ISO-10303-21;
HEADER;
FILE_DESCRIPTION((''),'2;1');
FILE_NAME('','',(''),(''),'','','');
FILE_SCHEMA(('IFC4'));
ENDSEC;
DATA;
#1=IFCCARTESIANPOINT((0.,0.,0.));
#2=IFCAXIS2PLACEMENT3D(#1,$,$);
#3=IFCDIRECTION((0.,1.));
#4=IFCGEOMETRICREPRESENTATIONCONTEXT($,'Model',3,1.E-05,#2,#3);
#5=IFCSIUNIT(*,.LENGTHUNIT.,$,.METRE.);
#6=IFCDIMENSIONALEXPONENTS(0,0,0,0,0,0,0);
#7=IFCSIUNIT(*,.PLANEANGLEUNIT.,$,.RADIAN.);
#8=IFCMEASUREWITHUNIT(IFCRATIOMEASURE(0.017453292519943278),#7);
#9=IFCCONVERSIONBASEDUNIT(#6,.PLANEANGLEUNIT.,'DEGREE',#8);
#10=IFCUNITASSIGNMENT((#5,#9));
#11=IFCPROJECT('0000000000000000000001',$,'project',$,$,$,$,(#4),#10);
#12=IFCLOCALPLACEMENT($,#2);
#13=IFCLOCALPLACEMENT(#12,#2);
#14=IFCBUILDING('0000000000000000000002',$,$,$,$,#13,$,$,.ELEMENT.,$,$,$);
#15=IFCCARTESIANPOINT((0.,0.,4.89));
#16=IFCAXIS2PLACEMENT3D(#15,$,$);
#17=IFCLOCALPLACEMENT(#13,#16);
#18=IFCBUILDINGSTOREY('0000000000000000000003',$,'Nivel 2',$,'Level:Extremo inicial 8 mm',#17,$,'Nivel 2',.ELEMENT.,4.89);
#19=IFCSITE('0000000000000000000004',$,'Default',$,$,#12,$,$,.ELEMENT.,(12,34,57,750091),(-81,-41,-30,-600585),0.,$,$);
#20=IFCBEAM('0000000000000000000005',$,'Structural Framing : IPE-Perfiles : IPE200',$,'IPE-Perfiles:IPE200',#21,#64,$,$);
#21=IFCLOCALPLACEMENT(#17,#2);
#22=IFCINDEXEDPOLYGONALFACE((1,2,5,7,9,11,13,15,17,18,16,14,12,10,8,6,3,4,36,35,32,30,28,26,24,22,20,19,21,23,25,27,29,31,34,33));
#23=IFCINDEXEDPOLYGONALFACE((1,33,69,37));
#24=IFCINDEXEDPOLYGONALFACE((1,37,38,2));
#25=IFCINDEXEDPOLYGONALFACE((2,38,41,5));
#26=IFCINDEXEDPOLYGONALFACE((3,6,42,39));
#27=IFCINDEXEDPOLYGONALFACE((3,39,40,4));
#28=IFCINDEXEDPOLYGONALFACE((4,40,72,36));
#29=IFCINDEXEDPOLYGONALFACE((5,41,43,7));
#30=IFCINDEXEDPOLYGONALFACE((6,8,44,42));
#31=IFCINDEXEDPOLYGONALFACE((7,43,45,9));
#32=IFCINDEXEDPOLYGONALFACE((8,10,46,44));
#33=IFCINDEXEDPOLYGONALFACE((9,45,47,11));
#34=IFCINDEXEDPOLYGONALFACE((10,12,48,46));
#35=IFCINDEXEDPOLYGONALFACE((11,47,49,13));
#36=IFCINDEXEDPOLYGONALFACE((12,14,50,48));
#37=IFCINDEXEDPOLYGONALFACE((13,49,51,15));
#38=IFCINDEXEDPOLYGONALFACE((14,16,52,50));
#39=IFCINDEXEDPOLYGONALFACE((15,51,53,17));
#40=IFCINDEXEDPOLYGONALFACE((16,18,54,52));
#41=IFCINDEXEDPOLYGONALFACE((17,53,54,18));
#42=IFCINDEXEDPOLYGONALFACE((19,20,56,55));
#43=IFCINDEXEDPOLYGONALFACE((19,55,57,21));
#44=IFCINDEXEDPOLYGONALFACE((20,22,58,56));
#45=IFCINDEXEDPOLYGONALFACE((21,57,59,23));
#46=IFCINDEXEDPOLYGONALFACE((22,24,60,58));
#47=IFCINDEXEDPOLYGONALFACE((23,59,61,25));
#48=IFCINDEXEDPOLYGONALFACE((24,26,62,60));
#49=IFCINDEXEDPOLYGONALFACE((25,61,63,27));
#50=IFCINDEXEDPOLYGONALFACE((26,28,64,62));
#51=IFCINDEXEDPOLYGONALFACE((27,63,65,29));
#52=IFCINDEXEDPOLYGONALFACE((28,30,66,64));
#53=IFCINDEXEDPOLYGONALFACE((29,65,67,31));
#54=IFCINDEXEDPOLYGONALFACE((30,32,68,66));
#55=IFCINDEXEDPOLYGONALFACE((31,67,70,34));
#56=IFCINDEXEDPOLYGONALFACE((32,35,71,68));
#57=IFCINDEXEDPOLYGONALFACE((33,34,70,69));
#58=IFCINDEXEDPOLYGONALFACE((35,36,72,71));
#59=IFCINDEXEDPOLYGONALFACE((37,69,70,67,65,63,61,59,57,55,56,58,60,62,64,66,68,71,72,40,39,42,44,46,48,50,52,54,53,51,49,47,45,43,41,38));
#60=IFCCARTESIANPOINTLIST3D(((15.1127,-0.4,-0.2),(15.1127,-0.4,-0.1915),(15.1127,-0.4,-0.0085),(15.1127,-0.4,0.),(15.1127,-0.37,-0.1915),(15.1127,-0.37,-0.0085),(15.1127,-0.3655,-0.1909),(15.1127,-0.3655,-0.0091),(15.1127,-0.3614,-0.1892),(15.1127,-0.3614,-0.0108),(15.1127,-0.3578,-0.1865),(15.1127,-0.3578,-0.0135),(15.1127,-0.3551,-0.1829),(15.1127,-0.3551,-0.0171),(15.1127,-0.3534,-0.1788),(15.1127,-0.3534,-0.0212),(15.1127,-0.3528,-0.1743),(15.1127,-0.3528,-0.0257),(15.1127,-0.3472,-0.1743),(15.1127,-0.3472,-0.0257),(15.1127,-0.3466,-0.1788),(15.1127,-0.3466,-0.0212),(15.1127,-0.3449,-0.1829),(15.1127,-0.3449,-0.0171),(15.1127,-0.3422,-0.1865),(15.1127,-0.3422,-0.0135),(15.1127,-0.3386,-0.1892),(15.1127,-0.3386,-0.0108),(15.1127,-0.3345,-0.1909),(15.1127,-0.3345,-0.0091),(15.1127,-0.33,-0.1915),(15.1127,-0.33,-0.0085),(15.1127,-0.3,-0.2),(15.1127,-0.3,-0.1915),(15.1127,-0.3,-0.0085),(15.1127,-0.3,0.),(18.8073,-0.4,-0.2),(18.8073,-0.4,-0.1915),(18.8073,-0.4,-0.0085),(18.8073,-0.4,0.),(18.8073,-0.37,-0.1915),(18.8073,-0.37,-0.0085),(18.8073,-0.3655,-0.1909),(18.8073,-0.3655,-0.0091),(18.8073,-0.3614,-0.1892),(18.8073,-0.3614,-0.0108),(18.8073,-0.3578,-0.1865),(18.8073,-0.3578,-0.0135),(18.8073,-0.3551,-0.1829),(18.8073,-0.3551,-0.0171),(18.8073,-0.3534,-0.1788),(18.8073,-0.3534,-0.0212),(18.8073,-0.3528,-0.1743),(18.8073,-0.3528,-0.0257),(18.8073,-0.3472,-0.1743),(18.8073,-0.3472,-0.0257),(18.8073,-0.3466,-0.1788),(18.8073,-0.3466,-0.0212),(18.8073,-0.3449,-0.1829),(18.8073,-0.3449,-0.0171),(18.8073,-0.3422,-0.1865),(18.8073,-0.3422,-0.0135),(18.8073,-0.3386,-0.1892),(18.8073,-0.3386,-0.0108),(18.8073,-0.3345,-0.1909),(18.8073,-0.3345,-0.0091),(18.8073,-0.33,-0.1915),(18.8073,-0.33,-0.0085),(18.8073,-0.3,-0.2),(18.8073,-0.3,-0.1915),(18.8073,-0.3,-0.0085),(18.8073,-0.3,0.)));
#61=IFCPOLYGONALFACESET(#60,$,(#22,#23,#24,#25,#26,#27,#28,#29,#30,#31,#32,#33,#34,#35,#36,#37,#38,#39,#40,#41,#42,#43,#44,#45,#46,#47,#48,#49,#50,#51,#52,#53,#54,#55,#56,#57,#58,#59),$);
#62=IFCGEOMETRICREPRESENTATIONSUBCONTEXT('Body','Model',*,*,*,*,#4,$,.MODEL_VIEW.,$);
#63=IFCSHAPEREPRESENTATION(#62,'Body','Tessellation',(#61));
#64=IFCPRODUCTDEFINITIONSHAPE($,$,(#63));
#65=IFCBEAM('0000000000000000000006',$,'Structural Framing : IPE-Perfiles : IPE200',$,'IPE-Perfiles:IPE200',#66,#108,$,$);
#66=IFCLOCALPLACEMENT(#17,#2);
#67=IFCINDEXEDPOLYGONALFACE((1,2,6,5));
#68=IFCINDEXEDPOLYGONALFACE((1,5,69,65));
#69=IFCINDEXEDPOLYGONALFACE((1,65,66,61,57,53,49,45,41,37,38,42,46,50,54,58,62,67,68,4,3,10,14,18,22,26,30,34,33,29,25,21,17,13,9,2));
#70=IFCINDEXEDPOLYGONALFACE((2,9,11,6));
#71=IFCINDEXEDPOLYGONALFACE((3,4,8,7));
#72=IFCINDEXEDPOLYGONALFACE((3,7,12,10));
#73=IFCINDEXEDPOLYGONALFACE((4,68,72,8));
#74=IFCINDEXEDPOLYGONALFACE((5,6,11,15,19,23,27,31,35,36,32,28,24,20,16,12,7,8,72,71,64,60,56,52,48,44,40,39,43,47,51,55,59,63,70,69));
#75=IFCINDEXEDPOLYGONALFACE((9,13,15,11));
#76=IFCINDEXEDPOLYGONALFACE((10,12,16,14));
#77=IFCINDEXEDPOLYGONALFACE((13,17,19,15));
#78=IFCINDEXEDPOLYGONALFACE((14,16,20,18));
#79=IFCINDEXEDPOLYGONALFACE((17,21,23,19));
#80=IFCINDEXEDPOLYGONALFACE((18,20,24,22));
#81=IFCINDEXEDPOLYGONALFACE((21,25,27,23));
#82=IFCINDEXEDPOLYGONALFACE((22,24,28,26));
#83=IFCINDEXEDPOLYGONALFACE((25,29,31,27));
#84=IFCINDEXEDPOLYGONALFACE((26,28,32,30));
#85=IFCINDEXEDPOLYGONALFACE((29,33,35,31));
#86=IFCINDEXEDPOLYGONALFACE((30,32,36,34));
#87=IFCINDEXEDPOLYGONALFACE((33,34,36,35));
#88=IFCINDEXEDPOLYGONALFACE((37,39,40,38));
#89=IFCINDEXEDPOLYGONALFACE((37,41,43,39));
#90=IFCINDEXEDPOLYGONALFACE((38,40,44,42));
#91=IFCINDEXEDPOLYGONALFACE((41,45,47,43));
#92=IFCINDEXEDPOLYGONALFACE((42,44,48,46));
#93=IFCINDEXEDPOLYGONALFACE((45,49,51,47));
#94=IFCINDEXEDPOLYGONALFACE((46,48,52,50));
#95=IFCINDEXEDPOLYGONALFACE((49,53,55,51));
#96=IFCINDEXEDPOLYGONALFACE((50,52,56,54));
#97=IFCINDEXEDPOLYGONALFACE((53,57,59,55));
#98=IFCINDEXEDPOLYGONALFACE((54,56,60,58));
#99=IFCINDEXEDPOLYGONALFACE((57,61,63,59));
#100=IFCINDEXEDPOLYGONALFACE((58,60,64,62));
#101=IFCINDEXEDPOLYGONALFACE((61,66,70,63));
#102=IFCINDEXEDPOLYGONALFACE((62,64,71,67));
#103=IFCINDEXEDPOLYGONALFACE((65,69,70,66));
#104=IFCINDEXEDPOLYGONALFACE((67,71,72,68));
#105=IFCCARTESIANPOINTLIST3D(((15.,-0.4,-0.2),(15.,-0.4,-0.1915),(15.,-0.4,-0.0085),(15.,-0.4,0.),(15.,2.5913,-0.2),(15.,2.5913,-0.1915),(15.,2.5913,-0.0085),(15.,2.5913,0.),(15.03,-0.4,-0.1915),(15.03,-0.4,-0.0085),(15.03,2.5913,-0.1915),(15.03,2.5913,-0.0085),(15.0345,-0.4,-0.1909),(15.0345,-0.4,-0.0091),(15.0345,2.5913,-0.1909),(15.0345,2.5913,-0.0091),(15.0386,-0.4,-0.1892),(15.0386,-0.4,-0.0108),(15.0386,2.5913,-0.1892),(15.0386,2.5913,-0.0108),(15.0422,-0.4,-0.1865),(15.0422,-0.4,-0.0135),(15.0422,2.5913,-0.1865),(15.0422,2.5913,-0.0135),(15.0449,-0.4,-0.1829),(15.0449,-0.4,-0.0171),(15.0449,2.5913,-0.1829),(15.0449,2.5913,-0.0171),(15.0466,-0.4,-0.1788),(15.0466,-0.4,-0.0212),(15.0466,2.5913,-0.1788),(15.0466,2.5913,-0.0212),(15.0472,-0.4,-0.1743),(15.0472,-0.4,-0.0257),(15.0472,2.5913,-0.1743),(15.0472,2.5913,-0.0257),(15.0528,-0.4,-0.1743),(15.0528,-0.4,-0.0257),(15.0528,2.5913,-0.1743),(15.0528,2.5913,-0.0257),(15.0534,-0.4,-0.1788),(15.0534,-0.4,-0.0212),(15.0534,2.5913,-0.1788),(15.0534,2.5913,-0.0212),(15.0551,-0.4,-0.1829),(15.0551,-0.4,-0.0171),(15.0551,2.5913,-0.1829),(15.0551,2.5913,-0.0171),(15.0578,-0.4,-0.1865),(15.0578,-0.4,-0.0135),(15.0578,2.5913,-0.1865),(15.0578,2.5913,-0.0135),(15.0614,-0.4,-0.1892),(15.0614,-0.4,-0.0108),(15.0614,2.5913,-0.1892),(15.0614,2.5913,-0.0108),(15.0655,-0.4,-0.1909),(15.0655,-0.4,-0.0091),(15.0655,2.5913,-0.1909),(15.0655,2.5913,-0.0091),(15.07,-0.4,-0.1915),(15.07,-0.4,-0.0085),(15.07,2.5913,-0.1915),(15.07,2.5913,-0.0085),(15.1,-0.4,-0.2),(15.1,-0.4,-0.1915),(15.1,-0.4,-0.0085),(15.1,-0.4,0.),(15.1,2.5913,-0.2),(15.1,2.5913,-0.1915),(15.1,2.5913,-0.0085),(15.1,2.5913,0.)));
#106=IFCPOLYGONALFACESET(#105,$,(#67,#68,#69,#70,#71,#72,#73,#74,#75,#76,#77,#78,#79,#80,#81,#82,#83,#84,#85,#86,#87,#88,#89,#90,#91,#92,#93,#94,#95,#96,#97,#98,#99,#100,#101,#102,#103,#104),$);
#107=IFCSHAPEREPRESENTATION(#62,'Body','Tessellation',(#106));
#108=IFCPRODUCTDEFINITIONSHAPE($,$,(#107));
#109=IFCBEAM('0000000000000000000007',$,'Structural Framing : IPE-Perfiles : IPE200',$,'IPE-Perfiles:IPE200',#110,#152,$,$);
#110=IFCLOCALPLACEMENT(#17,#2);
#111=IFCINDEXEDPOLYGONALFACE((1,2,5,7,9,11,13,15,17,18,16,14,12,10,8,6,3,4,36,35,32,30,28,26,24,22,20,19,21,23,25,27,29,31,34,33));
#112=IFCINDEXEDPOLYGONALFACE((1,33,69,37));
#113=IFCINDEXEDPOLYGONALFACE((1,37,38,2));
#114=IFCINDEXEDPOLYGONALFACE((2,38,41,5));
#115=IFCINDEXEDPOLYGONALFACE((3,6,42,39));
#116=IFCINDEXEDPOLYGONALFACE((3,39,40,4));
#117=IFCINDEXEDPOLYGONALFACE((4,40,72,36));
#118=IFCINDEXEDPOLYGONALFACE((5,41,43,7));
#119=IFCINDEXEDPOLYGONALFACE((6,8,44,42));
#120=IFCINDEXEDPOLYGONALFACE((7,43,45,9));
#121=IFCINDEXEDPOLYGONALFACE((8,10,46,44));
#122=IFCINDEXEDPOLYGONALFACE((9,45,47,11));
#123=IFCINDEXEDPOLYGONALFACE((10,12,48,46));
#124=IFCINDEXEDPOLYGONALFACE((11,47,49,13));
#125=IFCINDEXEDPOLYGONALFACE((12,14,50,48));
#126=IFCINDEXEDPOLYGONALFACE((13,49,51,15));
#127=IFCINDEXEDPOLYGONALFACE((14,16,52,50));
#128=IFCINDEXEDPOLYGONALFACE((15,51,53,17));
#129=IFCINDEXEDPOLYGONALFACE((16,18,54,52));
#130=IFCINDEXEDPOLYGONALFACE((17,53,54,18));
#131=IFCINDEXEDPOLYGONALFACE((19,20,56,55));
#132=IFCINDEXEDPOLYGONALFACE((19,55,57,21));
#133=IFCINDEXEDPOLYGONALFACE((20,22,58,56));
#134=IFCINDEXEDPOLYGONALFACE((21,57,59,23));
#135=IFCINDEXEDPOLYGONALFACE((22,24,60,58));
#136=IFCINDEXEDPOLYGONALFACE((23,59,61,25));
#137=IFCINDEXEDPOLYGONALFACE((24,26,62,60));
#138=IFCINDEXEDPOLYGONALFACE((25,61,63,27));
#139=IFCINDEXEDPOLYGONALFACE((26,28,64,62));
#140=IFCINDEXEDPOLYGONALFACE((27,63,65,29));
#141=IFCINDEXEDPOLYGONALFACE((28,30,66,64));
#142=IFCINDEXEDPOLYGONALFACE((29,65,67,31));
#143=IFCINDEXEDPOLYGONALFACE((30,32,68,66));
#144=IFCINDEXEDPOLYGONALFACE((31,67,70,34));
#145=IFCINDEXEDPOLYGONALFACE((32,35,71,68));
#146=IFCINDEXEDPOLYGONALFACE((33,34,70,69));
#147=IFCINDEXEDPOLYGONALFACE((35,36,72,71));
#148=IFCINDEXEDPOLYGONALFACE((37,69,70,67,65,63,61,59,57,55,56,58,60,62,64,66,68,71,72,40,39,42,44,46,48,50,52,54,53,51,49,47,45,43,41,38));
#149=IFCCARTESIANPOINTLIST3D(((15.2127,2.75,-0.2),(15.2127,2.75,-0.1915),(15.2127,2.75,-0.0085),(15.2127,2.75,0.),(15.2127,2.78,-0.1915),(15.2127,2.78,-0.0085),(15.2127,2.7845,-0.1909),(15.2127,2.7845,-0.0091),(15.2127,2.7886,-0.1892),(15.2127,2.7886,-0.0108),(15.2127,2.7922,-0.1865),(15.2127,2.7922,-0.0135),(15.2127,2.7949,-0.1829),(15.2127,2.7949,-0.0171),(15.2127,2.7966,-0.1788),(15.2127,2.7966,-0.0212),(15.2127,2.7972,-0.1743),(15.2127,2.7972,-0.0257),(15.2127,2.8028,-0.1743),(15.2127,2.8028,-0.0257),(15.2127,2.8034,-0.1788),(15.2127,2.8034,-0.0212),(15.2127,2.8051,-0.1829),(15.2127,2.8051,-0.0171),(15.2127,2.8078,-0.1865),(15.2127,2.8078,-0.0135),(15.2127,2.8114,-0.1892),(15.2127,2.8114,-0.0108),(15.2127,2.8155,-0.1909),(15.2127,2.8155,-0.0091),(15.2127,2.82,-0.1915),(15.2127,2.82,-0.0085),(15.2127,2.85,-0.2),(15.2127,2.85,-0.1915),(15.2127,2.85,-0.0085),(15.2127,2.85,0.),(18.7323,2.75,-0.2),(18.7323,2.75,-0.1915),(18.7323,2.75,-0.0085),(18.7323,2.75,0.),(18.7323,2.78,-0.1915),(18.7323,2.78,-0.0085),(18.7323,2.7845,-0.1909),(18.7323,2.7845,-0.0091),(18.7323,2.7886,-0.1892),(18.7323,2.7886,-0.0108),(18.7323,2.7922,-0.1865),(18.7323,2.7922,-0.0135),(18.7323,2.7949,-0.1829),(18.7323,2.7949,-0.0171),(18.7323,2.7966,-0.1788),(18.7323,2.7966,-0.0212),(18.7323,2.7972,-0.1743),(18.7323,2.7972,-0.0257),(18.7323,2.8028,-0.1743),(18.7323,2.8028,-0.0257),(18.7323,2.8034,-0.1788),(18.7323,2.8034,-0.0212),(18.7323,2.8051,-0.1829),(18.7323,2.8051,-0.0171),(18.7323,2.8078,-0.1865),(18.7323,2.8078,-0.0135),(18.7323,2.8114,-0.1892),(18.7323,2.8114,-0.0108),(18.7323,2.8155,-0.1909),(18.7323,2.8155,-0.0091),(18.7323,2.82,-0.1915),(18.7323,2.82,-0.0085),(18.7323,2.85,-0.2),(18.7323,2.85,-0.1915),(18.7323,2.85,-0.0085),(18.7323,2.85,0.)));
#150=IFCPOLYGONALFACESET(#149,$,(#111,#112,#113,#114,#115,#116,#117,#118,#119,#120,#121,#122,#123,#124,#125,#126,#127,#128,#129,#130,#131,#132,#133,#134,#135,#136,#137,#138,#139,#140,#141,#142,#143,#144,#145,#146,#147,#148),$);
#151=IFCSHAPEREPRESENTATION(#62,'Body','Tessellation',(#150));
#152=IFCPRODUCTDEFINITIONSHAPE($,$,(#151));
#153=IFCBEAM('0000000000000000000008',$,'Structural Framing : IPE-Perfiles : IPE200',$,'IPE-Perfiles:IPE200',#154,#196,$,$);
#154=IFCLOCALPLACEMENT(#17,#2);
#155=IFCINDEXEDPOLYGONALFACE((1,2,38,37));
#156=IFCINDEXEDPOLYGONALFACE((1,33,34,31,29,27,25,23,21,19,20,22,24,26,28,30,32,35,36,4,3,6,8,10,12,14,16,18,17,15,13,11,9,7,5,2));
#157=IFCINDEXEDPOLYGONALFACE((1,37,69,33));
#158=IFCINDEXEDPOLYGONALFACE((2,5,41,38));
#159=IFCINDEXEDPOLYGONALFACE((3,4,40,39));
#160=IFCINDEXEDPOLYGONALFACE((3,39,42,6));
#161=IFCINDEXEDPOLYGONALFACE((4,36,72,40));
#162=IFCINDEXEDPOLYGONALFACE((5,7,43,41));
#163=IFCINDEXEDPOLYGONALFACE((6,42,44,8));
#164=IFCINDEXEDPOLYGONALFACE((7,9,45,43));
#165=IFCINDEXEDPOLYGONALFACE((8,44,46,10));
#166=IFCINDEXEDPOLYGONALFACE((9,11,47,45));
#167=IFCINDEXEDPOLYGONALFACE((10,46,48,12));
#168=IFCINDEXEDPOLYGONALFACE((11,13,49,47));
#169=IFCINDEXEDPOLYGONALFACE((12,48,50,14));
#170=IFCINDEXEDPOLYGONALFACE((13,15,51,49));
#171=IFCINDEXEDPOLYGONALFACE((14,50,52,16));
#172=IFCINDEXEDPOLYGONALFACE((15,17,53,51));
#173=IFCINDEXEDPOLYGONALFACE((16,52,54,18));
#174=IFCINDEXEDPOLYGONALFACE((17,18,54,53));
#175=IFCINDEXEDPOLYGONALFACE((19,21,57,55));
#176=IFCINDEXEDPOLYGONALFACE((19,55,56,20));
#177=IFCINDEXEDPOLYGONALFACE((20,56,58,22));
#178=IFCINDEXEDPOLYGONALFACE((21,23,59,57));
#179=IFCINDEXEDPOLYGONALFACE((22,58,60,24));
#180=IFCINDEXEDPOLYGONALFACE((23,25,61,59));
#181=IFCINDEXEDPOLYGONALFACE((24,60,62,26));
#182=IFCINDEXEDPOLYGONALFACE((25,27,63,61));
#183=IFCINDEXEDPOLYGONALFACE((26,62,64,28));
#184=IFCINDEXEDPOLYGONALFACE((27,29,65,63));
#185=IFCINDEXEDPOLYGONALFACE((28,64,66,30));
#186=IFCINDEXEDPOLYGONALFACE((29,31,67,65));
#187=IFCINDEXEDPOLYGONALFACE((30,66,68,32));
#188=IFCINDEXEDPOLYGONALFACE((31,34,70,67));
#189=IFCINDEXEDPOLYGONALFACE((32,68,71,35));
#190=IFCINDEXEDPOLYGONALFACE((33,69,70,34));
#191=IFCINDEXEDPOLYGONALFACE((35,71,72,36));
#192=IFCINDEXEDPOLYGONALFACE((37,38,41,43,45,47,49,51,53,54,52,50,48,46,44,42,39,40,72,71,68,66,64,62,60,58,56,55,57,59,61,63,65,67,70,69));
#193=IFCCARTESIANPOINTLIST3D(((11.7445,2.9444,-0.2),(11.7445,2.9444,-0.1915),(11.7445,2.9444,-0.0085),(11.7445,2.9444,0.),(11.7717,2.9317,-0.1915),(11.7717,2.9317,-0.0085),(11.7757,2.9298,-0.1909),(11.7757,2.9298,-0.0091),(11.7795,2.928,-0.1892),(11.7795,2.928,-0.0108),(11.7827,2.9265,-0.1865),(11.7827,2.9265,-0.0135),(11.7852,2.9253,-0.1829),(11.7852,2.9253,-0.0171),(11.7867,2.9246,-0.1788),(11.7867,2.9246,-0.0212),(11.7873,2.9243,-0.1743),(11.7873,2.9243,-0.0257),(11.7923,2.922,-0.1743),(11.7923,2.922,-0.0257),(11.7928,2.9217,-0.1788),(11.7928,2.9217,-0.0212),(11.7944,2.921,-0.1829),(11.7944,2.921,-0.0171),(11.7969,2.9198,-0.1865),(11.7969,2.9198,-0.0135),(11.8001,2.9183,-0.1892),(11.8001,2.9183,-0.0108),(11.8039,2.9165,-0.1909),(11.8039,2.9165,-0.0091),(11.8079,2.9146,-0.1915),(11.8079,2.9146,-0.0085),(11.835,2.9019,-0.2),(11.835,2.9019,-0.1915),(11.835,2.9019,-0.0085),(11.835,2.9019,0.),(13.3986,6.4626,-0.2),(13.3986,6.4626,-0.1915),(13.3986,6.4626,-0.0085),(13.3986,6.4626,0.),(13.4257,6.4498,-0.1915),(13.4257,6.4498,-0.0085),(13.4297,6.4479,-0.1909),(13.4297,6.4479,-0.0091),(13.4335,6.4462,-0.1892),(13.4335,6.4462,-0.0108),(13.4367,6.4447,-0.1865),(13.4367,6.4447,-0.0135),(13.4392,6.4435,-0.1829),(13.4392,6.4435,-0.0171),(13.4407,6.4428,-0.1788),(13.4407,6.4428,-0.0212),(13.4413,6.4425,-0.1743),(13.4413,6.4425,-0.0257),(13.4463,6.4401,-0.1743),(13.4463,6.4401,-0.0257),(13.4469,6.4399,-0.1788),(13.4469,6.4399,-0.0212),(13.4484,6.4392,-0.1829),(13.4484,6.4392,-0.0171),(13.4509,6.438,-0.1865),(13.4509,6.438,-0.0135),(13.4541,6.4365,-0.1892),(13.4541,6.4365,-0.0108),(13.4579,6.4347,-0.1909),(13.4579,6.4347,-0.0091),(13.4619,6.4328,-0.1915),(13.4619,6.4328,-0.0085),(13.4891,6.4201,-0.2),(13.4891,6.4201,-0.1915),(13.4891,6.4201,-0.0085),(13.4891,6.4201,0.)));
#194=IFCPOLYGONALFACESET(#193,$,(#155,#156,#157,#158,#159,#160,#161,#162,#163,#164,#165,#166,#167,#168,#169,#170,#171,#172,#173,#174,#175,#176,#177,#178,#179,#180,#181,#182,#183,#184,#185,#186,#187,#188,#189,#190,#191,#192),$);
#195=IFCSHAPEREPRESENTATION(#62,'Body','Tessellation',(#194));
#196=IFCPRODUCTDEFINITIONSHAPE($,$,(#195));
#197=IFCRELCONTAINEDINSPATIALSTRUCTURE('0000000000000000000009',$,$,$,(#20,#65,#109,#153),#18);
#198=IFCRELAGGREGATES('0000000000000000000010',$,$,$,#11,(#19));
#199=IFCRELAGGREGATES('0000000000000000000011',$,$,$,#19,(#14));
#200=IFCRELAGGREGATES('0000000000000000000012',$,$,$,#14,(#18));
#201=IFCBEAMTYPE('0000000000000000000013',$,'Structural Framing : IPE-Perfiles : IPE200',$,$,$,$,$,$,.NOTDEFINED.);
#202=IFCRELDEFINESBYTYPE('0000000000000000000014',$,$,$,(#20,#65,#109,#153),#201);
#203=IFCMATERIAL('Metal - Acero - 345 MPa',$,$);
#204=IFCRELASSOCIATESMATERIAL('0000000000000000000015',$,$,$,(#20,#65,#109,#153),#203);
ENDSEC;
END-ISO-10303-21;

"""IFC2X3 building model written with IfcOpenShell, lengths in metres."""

from ifc_helpers import new_model, entity, si_unit, converted_unit, direction, frame, frame_2d, origin, place, context, subcontext, project, spatial, i_section, extrude, material, type_object, element, save


model = new_model("IFC2X3")

# Units and contexts
model_context = context("Model", 3, precision=1e-05, world=origin(), true_north=direction((0.0, 1.0)))
body_context = subcontext(model_context, "Body", "Model", "MODEL_VIEW")
ifc_project = project(units=[si_unit("LENGTHUNIT", "METRE"), converted_unit("PLANEANGLEUNIT", "DEGREE", entity("IfcRatioMeasure", 0.017453292519943278), si_unit("PLANEANGLEUNIT", "RADIAN"), dimensions=[0, 0, 0, 0, 0, 0, 0])], contexts=[model_context])

# Site, building, storey
site_placement = place(None, origin())
site = spatial("IfcSite", under=ifc_project, at=site_placement, Name="Default", CompositionType="ELEMENT", RefLatitude=(12, 34, 57, 750091), RefLongitude=(-81, -41, -30, -600585), RefElevation=0.0)
building_placement = place(site_placement, origin())
building = spatial("IfcBuilding", under=site, at=building_placement, CompositionType="ELEMENT")
storey_placement = place(building_placement, frame((0.0, 0.0, 4.89)))
storey = spatial("IfcBuildingStorey", under=building, at=storey_placement, Name="Nivel 2", ObjectType="Level:Extremo inicial 8 mm", LongName="Nivel 2", CompositionType="ELEMENT", Elevation=4.89)

# Shared definitions
ifc_material_1 = material(Name="Metal - Acero - 345 MPa")

# Beams
beam_type_1 = type_object("IfcBeamType", Name="Structural Framing : IPE-Perfiles : IPE200", PredefinedType="NOTDEFINED")
beam_1_placement = place(storey_placement, frame((15.05, -0.35, 0.0)))
element("IfcBeam", 1, at=beam_1_placement, inside=storey, type_object=beam_type_1, material=ifc_material_1, Name="Structural Framing : IPE-Perfiles : IPE200", ObjectType="IPE-Perfiles:IPE200", context=body_context, shape_type="SweptSolid", body=[
    extrude(i_section(OverallWidth=0.1, OverallDepth=0.2, WebThickness=0.0056, FlangeThickness=0.0085, FilletRadius=0.0172, at=frame_2d((0.0, 0.0), x_axis=(0.0, 1.0))), frame((0.0627, 0.0, -0.1), z_axis=(1.0, 0.0, 0.0), x_axis=(0.0, 0.0, -1.0)), (0.0, 0.0, 1.0), 3.6946),
])
beam_2_placement = place(storey_placement, frame((15.05, -0.35, 0.0), z_axis=(0.0, 0.0, 1.0), x_axis=(0.0, 1.0, 0.0)))
element("IfcBeam", 2, at=beam_2_placement, inside=storey, type_object=beam_type_1, material=ifc_material_1, Name="Structural Framing : IPE-Perfiles : IPE200", ObjectType="IPE-Perfiles:IPE200", context=body_context, shape_type="SweptSolid", body=[
    extrude(i_section(OverallWidth=0.1, OverallDepth=0.2, WebThickness=0.0056, FlangeThickness=0.0085, FilletRadius=0.0172, at=frame_2d((0.0, 0.0), x_axis=(0.0, 1.0))), frame((-0.05, 0.0, -0.1), z_axis=(1.0, 0.0, 0.0), x_axis=(0.0, 0.0, -1.0)), (0.0, 0.0, 1.0), 2.9913),
])
beam_3_placement = place(storey_placement, frame((15.05, 2.8, 0.0)))
element("IfcBeam", 3, at=beam_3_placement, inside=storey, type_object=beam_type_1, material=ifc_material_1, Name="Structural Framing : IPE-Perfiles : IPE200", ObjectType="IPE-Perfiles:IPE200", context=body_context, shape_type="SweptSolid", body=[
    extrude(i_section(OverallWidth=0.1, OverallDepth=0.2, WebThickness=0.0056, FlangeThickness=0.0085, FilletRadius=0.0172, at=frame_2d((0.0, 0.0), x_axis=(0.0, 1.0))), frame((0.1627, 0.0, -0.1), z_axis=(1.0, 0.0, 0.0), x_axis=(0.0, 0.0, -1.0)), (0.0, 0.0, 1.0), 3.5196),
])
beam_4_placement = place(storey_placement, frame((11.7319, 2.8, 0.0), z_axis=(0.0, 0.0, 1.0), x_axis=(0.42546, 0.904977, 0.0)))
element("IfcBeam", 4, at=beam_4_placement, inside=storey, type_object=beam_type_1, material=ifc_material_1, Name="Structural Framing : IPE-Perfiles : IPE200", ObjectType="IPE-Perfiles:IPE200", context=body_context, shape_type="SweptSolid", body=[
    extrude(i_section(OverallWidth=0.1, OverallDepth=0.2, WebThickness=0.0056, FlangeThickness=0.0085, FilletRadius=0.0172, at=frame_2d((0.0, 0.0), x_axis=(0.0, 1.0))), frame((0.1361, 0.0, -0.1), z_axis=(1.0, 0.0, 0.0), x_axis=(0.0, 0.0, -1.0)), (0.0, 0.0, 1.0), 3.8876),
])

save(model, "model.ifc")
